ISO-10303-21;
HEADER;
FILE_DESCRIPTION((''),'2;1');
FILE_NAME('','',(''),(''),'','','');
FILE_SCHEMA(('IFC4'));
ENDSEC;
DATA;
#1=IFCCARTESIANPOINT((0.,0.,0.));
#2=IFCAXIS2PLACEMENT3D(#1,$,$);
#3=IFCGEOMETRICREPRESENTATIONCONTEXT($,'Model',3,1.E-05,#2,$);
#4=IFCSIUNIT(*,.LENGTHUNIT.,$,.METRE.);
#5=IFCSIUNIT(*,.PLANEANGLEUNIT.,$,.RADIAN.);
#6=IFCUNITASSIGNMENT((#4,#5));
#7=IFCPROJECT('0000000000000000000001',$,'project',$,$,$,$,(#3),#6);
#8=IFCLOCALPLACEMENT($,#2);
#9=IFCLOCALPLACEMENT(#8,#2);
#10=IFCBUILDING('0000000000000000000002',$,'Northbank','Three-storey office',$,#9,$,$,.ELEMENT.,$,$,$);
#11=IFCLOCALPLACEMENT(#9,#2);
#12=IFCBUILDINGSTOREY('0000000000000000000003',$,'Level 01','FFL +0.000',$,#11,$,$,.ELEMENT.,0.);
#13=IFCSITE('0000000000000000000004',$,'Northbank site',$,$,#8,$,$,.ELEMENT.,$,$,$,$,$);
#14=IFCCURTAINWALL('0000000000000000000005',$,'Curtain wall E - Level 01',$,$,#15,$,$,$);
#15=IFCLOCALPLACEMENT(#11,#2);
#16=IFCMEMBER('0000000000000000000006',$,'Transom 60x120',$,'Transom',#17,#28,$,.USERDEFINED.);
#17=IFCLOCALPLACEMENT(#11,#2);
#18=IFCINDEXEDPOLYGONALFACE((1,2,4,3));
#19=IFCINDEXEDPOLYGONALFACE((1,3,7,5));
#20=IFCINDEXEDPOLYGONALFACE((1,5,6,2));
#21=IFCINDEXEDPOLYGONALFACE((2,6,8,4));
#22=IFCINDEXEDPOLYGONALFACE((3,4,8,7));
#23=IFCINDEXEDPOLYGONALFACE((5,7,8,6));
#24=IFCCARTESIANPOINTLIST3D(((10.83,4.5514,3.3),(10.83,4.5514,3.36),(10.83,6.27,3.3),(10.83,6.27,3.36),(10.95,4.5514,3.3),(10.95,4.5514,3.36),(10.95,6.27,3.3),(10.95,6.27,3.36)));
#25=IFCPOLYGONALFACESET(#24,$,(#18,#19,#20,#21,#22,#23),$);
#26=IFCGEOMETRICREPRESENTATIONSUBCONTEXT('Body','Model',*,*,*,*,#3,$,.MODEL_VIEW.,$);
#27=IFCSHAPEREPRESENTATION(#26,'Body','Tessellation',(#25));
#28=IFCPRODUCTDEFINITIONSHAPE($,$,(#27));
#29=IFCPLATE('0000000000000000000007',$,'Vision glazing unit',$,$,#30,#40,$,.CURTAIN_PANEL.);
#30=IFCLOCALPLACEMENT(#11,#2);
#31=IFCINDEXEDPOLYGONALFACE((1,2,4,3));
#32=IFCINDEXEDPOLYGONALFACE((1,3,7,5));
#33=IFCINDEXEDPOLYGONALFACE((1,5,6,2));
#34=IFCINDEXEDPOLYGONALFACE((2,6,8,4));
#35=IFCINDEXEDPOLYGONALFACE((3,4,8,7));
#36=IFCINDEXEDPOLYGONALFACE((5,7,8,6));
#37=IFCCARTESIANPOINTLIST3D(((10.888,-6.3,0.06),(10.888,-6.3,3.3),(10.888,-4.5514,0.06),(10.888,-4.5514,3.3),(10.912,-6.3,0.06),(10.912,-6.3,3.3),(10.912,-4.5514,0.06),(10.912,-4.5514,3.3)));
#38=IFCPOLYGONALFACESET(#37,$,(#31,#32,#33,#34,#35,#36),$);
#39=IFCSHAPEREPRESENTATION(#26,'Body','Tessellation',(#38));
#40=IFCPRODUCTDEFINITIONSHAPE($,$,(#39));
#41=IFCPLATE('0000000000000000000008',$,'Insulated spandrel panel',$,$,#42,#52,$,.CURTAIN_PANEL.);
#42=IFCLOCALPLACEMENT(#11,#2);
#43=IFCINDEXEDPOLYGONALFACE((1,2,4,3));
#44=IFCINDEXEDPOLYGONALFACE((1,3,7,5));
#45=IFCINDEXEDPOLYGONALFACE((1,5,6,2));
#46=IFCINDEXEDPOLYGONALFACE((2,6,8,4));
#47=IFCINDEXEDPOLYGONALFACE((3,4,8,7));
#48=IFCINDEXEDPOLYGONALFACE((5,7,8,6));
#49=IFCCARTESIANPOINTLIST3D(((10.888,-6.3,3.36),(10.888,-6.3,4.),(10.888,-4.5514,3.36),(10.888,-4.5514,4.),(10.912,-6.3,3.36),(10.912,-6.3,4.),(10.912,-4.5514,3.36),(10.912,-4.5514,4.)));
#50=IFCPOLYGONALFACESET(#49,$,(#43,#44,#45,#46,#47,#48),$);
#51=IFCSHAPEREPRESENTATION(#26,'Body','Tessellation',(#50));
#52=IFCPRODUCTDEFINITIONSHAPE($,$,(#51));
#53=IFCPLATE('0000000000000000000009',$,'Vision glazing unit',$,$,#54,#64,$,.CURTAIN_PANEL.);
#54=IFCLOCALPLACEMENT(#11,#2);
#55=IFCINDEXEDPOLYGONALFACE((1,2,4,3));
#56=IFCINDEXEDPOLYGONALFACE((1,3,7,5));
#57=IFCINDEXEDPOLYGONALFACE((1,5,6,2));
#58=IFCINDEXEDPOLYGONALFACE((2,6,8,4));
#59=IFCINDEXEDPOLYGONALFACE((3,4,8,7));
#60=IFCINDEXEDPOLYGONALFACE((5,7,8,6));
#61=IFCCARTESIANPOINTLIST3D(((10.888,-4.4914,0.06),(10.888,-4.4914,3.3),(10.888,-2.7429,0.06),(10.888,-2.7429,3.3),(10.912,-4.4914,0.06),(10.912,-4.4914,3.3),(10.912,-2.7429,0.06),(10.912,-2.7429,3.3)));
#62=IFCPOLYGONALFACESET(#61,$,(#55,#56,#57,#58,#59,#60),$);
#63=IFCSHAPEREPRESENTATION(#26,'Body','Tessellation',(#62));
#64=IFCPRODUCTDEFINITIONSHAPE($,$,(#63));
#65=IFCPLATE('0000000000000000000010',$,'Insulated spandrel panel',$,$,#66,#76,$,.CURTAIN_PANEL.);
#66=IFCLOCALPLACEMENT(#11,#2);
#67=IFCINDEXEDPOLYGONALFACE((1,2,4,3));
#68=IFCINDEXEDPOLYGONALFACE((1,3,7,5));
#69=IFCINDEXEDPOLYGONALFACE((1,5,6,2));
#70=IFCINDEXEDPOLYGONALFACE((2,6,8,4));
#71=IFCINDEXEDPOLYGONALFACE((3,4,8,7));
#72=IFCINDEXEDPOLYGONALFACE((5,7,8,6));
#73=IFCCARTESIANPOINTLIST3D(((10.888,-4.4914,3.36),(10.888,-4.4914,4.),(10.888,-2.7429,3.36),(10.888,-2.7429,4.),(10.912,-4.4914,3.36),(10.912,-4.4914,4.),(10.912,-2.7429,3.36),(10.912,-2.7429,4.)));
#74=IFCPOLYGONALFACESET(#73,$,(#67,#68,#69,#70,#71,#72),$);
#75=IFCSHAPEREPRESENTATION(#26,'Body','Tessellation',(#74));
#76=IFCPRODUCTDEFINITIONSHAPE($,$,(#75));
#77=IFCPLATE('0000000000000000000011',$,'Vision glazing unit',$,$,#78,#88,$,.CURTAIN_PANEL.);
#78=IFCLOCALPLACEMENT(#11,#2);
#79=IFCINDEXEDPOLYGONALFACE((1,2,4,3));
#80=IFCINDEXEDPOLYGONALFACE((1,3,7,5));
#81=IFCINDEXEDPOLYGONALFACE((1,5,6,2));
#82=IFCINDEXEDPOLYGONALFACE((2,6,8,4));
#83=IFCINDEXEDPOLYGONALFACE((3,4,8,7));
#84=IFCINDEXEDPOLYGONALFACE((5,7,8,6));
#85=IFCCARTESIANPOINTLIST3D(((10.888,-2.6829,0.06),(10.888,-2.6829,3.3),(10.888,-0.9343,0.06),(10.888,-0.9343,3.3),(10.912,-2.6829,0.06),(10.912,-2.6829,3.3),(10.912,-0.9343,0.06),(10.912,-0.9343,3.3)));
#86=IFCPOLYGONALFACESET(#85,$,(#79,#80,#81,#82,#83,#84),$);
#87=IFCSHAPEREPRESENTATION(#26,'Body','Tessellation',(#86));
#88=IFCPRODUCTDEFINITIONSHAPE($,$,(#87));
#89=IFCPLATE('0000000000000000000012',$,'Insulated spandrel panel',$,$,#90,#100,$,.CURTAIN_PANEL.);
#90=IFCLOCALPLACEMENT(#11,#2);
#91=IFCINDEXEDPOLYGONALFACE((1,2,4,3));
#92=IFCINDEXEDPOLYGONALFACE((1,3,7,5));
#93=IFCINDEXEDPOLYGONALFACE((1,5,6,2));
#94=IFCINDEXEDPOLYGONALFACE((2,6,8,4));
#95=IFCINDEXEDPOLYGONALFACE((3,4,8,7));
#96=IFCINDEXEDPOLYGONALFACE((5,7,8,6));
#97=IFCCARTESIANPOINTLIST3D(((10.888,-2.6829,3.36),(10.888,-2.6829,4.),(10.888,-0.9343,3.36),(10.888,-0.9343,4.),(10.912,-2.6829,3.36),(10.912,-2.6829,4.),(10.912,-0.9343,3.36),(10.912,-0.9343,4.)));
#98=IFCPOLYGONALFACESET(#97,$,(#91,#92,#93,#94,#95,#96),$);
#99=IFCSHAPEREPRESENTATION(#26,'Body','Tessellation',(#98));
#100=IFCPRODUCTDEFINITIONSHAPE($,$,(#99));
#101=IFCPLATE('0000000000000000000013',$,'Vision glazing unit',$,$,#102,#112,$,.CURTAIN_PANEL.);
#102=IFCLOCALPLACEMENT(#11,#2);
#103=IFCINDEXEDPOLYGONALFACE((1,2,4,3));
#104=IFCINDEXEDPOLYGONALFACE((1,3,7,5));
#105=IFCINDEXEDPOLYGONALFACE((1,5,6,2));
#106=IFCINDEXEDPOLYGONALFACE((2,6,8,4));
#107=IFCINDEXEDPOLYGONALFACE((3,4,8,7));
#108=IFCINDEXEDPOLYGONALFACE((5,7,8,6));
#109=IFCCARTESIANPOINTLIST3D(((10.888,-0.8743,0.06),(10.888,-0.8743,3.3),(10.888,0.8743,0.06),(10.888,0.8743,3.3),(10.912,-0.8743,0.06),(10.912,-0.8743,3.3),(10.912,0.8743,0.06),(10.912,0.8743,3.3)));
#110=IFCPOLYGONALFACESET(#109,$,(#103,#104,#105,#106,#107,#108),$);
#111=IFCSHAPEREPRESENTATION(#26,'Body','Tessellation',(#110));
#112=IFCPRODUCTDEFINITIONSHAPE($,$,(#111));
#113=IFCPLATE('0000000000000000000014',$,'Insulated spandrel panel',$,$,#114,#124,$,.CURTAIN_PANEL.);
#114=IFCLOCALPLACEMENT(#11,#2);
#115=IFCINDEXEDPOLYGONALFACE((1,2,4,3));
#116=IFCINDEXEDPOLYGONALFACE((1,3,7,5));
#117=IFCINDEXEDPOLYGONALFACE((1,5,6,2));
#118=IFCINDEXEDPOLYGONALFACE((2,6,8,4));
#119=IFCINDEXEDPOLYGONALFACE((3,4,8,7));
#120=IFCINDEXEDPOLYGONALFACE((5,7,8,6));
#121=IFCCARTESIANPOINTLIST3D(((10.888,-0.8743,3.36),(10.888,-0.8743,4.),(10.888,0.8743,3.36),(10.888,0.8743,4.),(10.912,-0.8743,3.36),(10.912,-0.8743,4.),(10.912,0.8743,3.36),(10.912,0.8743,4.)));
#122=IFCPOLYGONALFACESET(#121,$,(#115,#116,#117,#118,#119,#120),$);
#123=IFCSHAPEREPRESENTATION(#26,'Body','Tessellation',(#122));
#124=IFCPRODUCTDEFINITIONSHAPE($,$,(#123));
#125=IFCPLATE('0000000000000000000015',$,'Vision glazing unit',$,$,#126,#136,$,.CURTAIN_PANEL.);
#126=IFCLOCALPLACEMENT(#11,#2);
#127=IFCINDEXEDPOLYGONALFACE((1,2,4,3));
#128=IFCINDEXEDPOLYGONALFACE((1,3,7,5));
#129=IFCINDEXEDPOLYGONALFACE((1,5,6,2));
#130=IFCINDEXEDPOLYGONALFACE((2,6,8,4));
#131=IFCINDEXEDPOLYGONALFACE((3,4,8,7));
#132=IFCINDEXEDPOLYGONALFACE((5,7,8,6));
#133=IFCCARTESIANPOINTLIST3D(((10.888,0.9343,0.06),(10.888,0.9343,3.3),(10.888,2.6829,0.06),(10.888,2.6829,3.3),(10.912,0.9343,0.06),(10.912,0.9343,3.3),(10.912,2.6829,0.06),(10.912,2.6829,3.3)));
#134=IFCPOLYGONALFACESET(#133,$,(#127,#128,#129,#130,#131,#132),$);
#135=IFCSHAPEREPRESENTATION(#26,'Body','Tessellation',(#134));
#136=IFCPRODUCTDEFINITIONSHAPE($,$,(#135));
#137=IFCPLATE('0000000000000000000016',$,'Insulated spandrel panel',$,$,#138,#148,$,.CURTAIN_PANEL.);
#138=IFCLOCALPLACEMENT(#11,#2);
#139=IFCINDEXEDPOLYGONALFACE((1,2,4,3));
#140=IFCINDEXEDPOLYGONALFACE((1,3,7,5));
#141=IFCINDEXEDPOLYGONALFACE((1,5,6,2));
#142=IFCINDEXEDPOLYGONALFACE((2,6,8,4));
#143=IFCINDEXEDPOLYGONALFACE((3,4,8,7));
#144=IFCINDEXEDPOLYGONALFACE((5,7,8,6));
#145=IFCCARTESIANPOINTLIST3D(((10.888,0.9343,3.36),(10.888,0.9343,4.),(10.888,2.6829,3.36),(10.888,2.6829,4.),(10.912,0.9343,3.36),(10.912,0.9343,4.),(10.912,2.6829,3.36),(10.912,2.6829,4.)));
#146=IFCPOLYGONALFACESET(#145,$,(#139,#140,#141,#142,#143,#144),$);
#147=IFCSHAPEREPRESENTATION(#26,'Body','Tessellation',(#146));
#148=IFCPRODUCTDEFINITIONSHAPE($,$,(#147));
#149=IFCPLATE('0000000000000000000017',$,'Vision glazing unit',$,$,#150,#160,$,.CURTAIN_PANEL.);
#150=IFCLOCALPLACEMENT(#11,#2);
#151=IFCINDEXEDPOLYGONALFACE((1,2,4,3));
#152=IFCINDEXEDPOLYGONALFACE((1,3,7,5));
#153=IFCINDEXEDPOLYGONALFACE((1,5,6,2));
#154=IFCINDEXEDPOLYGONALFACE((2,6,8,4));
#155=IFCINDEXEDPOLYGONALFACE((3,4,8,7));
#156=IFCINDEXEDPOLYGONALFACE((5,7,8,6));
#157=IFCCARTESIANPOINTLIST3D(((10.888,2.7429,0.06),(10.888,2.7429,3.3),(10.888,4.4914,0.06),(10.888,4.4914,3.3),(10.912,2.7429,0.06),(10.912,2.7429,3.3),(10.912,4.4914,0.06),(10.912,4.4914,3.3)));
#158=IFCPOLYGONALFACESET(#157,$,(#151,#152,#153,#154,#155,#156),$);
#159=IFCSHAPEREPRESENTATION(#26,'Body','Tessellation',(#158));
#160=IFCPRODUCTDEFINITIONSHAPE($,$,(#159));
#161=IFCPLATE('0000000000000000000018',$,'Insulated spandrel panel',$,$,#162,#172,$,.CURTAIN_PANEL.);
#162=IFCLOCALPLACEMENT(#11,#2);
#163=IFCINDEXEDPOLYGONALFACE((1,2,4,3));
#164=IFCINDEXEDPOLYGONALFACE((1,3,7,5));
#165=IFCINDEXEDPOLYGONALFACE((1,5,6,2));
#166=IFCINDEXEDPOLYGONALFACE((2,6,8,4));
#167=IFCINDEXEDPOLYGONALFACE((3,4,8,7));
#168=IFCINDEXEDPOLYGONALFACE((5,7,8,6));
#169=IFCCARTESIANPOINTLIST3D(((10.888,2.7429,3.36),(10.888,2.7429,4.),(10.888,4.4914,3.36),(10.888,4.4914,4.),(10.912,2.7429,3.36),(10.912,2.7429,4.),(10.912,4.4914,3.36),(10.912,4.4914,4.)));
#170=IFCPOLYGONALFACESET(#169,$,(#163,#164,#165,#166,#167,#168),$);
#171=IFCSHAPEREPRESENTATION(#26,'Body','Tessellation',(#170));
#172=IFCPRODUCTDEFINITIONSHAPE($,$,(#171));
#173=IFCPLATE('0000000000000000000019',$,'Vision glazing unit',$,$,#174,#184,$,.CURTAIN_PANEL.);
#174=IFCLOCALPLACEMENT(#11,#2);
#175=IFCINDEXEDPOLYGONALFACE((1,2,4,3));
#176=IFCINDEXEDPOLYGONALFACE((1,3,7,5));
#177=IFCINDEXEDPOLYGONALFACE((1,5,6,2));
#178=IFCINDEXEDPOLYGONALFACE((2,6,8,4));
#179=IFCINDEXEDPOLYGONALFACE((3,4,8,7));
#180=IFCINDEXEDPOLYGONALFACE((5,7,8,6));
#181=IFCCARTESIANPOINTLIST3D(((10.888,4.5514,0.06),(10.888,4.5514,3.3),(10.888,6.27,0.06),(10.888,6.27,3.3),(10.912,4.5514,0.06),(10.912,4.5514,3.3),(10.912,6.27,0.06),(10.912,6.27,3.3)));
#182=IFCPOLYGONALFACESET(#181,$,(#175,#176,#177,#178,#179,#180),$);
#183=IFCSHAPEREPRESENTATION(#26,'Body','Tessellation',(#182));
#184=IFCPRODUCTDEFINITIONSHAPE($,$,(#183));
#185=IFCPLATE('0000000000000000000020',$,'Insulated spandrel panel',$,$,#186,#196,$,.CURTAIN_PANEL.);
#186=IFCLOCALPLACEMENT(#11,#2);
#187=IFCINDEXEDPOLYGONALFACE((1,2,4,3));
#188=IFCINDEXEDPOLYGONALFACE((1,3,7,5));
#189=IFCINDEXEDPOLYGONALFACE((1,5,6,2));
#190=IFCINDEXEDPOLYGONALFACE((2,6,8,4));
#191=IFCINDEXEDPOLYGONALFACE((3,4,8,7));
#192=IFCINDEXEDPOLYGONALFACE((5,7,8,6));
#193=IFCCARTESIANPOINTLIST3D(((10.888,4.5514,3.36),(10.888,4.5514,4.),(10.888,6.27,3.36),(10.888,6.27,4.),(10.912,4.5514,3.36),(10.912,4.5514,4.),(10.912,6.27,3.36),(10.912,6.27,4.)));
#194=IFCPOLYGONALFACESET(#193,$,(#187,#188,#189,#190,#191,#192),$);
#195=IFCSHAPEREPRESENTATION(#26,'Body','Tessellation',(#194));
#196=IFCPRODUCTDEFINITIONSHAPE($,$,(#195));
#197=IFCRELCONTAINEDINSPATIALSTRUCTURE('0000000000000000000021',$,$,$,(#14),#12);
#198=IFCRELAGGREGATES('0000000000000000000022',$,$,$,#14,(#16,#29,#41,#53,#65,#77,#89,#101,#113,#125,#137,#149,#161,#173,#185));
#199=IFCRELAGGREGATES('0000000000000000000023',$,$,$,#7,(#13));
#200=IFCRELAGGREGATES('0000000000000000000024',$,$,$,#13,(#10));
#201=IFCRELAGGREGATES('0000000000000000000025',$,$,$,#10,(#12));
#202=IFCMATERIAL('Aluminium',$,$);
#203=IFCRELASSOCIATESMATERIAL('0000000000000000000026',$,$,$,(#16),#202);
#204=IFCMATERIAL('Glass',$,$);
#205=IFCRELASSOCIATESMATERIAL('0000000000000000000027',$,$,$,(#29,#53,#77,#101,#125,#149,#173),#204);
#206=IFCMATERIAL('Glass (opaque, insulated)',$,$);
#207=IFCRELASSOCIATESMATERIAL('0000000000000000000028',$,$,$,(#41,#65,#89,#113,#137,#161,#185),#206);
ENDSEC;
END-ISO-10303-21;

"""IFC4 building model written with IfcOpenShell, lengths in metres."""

from ifc_helpers import new_model, si_unit, frame, origin, place, context, subcontext, project, spatial, rectangle, extrude, material, element, aggregate, save


model = new_model("IFC4")

# Units and contexts
model_context = context("Model", 3, precision=1e-05, world=origin())
body_context = subcontext(model_context, "Body", "Model", "MODEL_VIEW")
ifc_project = project(units=[si_unit("LENGTHUNIT", "METRE"), si_unit("PLANEANGLEUNIT", "RADIAN")], contexts=[model_context])

# Site, building, storey
site_placement = place(None, origin())
site = spatial("IfcSite", under=ifc_project, at=site_placement, Name="Northbank site", CompositionType="ELEMENT")
building_placement = place(site_placement, origin())
building = spatial("IfcBuilding", under=site, at=building_placement, Name="Northbank", Description="Three-storey office", CompositionType="ELEMENT")
storey_placement = place(building_placement, origin())
storey = spatial("IfcBuildingStorey", under=building, at=storey_placement, Name="Level 01", Description="FFL +0.000", CompositionType="ELEMENT", Elevation=0.0)

# Curtain wall, member, plates
curtain_wall_placement = place(storey_placement, origin())
curtain_wall = element("IfcCurtainWall", 1, at=curtain_wall_placement, inside=storey, Name="Curtain wall E - Level 01")
ifc_material_1 = material(Name="Aluminium")
member_placement = place(storey_placement, origin())
member = element("IfcMember", 2, at=member_placement, material=ifc_material_1, Name="Transom 60x120", ObjectType="Transom", PredefinedType="USERDEFINED", context=body_context, shape_type="SweptSolid", body=[
    extrude(rectangle(XDim=0.12, YDim=1.7186), frame((10.89, 5.4107, 3.3)), (0.0, 0.0, 1.0), 0.06),
])
ifc_material_2 = material(Name="Glass")
plate_1_placement = place(storey_placement, origin())
plate_1 = element("IfcPlate", 3, at=plate_1_placement, material=ifc_material_2, Name="Vision glazing unit", PredefinedType="CURTAIN_PANEL", context=body_context, shape_type="SweptSolid", body=[
    extrude(rectangle(XDim=0.024, YDim=1.7486), frame((10.9, -5.4257, 0.06)), (0.0, 0.0, 1.0), 3.24),
])
ifc_material_3 = material(Name="Glass (opaque, insulated)")
plate_2_placement = place(storey_placement, origin())
plate_2 = element("IfcPlate", 4, at=plate_2_placement, material=ifc_material_3, Name="Insulated spandrel panel", PredefinedType="CURTAIN_PANEL", context=body_context, shape_type="SweptSolid", body=[
    extrude(rectangle(XDim=0.024, YDim=1.7486), frame((10.9, -5.4257, 3.36)), (0.0, 0.0, 1.0), 0.64),
])
plate_3_placement = place(storey_placement, origin())
plate_3 = element("IfcPlate", 5, at=plate_3_placement, material=ifc_material_2, Name="Vision glazing unit", PredefinedType="CURTAIN_PANEL", context=body_context, shape_type="SweptSolid", body=[
    extrude(rectangle(XDim=0.024, YDim=1.7486), frame((10.9, -3.6171, 0.06)), (0.0, 0.0, 1.0), 3.24),
])
plate_4_placement = place(storey_placement, origin())
plate_4 = element("IfcPlate", 6, at=plate_4_placement, material=ifc_material_3, Name="Insulated spandrel panel", PredefinedType="CURTAIN_PANEL", context=body_context, shape_type="SweptSolid", body=[
    extrude(rectangle(XDim=0.024, YDim=1.7486), frame((10.9, -3.6171, 3.36)), (0.0, 0.0, 1.0), 0.64),
])
plate_5_placement = place(storey_placement, origin())
plate_5 = element("IfcPlate", 7, at=plate_5_placement, material=ifc_material_2, Name="Vision glazing unit", PredefinedType="CURTAIN_PANEL", context=body_context, shape_type="SweptSolid", body=[
    extrude(rectangle(XDim=0.024, YDim=1.7486), frame((10.9, -1.8086, 0.06)), (0.0, 0.0, 1.0), 3.24),
])
plate_6_placement = place(storey_placement, origin())
plate_6 = element("IfcPlate", 8, at=plate_6_placement, material=ifc_material_3, Name="Insulated spandrel panel", PredefinedType="CURTAIN_PANEL", context=body_context, shape_type="SweptSolid", body=[
    extrude(rectangle(XDim=0.024, YDim=1.7486), frame((10.9, -1.8086, 3.36)), (0.0, 0.0, 1.0), 0.64),
])
plate_7_placement = place(storey_placement, origin())
plate_7 = element("IfcPlate", 9, at=plate_7_placement, material=ifc_material_2, Name="Vision glazing unit", PredefinedType="CURTAIN_PANEL", context=body_context, shape_type="SweptSolid", body=[
    extrude(rectangle(XDim=0.024, YDim=1.7486), frame((10.9, 0.0, 0.06)), (0.0, 0.0, 1.0), 3.24),
])
plate_8_placement = place(storey_placement, origin())
plate_8 = element("IfcPlate", 10, at=plate_8_placement, material=ifc_material_3, Name="Insulated spandrel panel", PredefinedType="CURTAIN_PANEL", context=body_context, shape_type="SweptSolid", body=[
    extrude(rectangle(XDim=0.024, YDim=1.7486), frame((10.9, 0.0, 3.36)), (0.0, 0.0, 1.0), 0.64),
])
plate_9_placement = place(storey_placement, origin())
plate_9 = element("IfcPlate", 11, at=plate_9_placement, material=ifc_material_2, Name="Vision glazing unit", PredefinedType="CURTAIN_PANEL", context=body_context, shape_type="SweptSolid", body=[
    extrude(rectangle(XDim=0.024, YDim=1.7486), frame((10.9, 1.8086, 0.06)), (0.0, 0.0, 1.0), 3.24),
])
plate_10_placement = place(storey_placement, origin())
plate_10 = element("IfcPlate", 12, at=plate_10_placement, material=ifc_material_3, Name="Insulated spandrel panel", PredefinedType="CURTAIN_PANEL", context=body_context, shape_type="SweptSolid", body=[
    extrude(rectangle(XDim=0.024, YDim=1.7486), frame((10.9, 1.8086, 3.36)), (0.0, 0.0, 1.0), 0.64),
])
plate_11_placement = place(storey_placement, origin())
plate_11 = element("IfcPlate", 13, at=plate_11_placement, material=ifc_material_2, Name="Vision glazing unit", PredefinedType="CURTAIN_PANEL", context=body_context, shape_type="SweptSolid", body=[
    extrude(rectangle(XDim=0.024, YDim=1.7486), frame((10.9, 3.6171, 0.06)), (0.0, 0.0, 1.0), 3.24),
])
plate_12_placement = place(storey_placement, origin())
plate_12 = element("IfcPlate", 14, at=plate_12_placement, material=ifc_material_3, Name="Insulated spandrel panel", PredefinedType="CURTAIN_PANEL", context=body_context, shape_type="SweptSolid", body=[
    extrude(rectangle(XDim=0.024, YDim=1.7486), frame((10.9, 3.6171, 3.36)), (0.0, 0.0, 1.0), 0.64),
])
plate_13_placement = place(storey_placement, origin())
plate_13 = element("IfcPlate", 15, at=plate_13_placement, material=ifc_material_2, Name="Vision glazing unit", PredefinedType="CURTAIN_PANEL", context=body_context, shape_type="SweptSolid", body=[
    extrude(rectangle(XDim=0.024, YDim=1.7186), frame((10.9, 5.4107, 0.06)), (0.0, 0.0, 1.0), 3.24),
])
plate_14_placement = place(storey_placement, origin())
plate_14 = element("IfcPlate", 16, at=plate_14_placement, material=ifc_material_3, Name="Insulated spandrel panel", PredefinedType="CURTAIN_PANEL", context=body_context, shape_type="SweptSolid", body=[
    extrude(rectangle(XDim=0.024, YDim=1.7186), frame((10.9, 5.4107, 3.36)), (0.0, 0.0, 1.0), 0.64),
])
aggregate(curtain_wall, [member, plate_1, plate_2, plate_3, plate_4, plate_5, plate_6, plate_7, plate_8, plate_9, plate_10, plate_11, plate_12, plate_13, plate_14])

save(model, "model.ifc")
